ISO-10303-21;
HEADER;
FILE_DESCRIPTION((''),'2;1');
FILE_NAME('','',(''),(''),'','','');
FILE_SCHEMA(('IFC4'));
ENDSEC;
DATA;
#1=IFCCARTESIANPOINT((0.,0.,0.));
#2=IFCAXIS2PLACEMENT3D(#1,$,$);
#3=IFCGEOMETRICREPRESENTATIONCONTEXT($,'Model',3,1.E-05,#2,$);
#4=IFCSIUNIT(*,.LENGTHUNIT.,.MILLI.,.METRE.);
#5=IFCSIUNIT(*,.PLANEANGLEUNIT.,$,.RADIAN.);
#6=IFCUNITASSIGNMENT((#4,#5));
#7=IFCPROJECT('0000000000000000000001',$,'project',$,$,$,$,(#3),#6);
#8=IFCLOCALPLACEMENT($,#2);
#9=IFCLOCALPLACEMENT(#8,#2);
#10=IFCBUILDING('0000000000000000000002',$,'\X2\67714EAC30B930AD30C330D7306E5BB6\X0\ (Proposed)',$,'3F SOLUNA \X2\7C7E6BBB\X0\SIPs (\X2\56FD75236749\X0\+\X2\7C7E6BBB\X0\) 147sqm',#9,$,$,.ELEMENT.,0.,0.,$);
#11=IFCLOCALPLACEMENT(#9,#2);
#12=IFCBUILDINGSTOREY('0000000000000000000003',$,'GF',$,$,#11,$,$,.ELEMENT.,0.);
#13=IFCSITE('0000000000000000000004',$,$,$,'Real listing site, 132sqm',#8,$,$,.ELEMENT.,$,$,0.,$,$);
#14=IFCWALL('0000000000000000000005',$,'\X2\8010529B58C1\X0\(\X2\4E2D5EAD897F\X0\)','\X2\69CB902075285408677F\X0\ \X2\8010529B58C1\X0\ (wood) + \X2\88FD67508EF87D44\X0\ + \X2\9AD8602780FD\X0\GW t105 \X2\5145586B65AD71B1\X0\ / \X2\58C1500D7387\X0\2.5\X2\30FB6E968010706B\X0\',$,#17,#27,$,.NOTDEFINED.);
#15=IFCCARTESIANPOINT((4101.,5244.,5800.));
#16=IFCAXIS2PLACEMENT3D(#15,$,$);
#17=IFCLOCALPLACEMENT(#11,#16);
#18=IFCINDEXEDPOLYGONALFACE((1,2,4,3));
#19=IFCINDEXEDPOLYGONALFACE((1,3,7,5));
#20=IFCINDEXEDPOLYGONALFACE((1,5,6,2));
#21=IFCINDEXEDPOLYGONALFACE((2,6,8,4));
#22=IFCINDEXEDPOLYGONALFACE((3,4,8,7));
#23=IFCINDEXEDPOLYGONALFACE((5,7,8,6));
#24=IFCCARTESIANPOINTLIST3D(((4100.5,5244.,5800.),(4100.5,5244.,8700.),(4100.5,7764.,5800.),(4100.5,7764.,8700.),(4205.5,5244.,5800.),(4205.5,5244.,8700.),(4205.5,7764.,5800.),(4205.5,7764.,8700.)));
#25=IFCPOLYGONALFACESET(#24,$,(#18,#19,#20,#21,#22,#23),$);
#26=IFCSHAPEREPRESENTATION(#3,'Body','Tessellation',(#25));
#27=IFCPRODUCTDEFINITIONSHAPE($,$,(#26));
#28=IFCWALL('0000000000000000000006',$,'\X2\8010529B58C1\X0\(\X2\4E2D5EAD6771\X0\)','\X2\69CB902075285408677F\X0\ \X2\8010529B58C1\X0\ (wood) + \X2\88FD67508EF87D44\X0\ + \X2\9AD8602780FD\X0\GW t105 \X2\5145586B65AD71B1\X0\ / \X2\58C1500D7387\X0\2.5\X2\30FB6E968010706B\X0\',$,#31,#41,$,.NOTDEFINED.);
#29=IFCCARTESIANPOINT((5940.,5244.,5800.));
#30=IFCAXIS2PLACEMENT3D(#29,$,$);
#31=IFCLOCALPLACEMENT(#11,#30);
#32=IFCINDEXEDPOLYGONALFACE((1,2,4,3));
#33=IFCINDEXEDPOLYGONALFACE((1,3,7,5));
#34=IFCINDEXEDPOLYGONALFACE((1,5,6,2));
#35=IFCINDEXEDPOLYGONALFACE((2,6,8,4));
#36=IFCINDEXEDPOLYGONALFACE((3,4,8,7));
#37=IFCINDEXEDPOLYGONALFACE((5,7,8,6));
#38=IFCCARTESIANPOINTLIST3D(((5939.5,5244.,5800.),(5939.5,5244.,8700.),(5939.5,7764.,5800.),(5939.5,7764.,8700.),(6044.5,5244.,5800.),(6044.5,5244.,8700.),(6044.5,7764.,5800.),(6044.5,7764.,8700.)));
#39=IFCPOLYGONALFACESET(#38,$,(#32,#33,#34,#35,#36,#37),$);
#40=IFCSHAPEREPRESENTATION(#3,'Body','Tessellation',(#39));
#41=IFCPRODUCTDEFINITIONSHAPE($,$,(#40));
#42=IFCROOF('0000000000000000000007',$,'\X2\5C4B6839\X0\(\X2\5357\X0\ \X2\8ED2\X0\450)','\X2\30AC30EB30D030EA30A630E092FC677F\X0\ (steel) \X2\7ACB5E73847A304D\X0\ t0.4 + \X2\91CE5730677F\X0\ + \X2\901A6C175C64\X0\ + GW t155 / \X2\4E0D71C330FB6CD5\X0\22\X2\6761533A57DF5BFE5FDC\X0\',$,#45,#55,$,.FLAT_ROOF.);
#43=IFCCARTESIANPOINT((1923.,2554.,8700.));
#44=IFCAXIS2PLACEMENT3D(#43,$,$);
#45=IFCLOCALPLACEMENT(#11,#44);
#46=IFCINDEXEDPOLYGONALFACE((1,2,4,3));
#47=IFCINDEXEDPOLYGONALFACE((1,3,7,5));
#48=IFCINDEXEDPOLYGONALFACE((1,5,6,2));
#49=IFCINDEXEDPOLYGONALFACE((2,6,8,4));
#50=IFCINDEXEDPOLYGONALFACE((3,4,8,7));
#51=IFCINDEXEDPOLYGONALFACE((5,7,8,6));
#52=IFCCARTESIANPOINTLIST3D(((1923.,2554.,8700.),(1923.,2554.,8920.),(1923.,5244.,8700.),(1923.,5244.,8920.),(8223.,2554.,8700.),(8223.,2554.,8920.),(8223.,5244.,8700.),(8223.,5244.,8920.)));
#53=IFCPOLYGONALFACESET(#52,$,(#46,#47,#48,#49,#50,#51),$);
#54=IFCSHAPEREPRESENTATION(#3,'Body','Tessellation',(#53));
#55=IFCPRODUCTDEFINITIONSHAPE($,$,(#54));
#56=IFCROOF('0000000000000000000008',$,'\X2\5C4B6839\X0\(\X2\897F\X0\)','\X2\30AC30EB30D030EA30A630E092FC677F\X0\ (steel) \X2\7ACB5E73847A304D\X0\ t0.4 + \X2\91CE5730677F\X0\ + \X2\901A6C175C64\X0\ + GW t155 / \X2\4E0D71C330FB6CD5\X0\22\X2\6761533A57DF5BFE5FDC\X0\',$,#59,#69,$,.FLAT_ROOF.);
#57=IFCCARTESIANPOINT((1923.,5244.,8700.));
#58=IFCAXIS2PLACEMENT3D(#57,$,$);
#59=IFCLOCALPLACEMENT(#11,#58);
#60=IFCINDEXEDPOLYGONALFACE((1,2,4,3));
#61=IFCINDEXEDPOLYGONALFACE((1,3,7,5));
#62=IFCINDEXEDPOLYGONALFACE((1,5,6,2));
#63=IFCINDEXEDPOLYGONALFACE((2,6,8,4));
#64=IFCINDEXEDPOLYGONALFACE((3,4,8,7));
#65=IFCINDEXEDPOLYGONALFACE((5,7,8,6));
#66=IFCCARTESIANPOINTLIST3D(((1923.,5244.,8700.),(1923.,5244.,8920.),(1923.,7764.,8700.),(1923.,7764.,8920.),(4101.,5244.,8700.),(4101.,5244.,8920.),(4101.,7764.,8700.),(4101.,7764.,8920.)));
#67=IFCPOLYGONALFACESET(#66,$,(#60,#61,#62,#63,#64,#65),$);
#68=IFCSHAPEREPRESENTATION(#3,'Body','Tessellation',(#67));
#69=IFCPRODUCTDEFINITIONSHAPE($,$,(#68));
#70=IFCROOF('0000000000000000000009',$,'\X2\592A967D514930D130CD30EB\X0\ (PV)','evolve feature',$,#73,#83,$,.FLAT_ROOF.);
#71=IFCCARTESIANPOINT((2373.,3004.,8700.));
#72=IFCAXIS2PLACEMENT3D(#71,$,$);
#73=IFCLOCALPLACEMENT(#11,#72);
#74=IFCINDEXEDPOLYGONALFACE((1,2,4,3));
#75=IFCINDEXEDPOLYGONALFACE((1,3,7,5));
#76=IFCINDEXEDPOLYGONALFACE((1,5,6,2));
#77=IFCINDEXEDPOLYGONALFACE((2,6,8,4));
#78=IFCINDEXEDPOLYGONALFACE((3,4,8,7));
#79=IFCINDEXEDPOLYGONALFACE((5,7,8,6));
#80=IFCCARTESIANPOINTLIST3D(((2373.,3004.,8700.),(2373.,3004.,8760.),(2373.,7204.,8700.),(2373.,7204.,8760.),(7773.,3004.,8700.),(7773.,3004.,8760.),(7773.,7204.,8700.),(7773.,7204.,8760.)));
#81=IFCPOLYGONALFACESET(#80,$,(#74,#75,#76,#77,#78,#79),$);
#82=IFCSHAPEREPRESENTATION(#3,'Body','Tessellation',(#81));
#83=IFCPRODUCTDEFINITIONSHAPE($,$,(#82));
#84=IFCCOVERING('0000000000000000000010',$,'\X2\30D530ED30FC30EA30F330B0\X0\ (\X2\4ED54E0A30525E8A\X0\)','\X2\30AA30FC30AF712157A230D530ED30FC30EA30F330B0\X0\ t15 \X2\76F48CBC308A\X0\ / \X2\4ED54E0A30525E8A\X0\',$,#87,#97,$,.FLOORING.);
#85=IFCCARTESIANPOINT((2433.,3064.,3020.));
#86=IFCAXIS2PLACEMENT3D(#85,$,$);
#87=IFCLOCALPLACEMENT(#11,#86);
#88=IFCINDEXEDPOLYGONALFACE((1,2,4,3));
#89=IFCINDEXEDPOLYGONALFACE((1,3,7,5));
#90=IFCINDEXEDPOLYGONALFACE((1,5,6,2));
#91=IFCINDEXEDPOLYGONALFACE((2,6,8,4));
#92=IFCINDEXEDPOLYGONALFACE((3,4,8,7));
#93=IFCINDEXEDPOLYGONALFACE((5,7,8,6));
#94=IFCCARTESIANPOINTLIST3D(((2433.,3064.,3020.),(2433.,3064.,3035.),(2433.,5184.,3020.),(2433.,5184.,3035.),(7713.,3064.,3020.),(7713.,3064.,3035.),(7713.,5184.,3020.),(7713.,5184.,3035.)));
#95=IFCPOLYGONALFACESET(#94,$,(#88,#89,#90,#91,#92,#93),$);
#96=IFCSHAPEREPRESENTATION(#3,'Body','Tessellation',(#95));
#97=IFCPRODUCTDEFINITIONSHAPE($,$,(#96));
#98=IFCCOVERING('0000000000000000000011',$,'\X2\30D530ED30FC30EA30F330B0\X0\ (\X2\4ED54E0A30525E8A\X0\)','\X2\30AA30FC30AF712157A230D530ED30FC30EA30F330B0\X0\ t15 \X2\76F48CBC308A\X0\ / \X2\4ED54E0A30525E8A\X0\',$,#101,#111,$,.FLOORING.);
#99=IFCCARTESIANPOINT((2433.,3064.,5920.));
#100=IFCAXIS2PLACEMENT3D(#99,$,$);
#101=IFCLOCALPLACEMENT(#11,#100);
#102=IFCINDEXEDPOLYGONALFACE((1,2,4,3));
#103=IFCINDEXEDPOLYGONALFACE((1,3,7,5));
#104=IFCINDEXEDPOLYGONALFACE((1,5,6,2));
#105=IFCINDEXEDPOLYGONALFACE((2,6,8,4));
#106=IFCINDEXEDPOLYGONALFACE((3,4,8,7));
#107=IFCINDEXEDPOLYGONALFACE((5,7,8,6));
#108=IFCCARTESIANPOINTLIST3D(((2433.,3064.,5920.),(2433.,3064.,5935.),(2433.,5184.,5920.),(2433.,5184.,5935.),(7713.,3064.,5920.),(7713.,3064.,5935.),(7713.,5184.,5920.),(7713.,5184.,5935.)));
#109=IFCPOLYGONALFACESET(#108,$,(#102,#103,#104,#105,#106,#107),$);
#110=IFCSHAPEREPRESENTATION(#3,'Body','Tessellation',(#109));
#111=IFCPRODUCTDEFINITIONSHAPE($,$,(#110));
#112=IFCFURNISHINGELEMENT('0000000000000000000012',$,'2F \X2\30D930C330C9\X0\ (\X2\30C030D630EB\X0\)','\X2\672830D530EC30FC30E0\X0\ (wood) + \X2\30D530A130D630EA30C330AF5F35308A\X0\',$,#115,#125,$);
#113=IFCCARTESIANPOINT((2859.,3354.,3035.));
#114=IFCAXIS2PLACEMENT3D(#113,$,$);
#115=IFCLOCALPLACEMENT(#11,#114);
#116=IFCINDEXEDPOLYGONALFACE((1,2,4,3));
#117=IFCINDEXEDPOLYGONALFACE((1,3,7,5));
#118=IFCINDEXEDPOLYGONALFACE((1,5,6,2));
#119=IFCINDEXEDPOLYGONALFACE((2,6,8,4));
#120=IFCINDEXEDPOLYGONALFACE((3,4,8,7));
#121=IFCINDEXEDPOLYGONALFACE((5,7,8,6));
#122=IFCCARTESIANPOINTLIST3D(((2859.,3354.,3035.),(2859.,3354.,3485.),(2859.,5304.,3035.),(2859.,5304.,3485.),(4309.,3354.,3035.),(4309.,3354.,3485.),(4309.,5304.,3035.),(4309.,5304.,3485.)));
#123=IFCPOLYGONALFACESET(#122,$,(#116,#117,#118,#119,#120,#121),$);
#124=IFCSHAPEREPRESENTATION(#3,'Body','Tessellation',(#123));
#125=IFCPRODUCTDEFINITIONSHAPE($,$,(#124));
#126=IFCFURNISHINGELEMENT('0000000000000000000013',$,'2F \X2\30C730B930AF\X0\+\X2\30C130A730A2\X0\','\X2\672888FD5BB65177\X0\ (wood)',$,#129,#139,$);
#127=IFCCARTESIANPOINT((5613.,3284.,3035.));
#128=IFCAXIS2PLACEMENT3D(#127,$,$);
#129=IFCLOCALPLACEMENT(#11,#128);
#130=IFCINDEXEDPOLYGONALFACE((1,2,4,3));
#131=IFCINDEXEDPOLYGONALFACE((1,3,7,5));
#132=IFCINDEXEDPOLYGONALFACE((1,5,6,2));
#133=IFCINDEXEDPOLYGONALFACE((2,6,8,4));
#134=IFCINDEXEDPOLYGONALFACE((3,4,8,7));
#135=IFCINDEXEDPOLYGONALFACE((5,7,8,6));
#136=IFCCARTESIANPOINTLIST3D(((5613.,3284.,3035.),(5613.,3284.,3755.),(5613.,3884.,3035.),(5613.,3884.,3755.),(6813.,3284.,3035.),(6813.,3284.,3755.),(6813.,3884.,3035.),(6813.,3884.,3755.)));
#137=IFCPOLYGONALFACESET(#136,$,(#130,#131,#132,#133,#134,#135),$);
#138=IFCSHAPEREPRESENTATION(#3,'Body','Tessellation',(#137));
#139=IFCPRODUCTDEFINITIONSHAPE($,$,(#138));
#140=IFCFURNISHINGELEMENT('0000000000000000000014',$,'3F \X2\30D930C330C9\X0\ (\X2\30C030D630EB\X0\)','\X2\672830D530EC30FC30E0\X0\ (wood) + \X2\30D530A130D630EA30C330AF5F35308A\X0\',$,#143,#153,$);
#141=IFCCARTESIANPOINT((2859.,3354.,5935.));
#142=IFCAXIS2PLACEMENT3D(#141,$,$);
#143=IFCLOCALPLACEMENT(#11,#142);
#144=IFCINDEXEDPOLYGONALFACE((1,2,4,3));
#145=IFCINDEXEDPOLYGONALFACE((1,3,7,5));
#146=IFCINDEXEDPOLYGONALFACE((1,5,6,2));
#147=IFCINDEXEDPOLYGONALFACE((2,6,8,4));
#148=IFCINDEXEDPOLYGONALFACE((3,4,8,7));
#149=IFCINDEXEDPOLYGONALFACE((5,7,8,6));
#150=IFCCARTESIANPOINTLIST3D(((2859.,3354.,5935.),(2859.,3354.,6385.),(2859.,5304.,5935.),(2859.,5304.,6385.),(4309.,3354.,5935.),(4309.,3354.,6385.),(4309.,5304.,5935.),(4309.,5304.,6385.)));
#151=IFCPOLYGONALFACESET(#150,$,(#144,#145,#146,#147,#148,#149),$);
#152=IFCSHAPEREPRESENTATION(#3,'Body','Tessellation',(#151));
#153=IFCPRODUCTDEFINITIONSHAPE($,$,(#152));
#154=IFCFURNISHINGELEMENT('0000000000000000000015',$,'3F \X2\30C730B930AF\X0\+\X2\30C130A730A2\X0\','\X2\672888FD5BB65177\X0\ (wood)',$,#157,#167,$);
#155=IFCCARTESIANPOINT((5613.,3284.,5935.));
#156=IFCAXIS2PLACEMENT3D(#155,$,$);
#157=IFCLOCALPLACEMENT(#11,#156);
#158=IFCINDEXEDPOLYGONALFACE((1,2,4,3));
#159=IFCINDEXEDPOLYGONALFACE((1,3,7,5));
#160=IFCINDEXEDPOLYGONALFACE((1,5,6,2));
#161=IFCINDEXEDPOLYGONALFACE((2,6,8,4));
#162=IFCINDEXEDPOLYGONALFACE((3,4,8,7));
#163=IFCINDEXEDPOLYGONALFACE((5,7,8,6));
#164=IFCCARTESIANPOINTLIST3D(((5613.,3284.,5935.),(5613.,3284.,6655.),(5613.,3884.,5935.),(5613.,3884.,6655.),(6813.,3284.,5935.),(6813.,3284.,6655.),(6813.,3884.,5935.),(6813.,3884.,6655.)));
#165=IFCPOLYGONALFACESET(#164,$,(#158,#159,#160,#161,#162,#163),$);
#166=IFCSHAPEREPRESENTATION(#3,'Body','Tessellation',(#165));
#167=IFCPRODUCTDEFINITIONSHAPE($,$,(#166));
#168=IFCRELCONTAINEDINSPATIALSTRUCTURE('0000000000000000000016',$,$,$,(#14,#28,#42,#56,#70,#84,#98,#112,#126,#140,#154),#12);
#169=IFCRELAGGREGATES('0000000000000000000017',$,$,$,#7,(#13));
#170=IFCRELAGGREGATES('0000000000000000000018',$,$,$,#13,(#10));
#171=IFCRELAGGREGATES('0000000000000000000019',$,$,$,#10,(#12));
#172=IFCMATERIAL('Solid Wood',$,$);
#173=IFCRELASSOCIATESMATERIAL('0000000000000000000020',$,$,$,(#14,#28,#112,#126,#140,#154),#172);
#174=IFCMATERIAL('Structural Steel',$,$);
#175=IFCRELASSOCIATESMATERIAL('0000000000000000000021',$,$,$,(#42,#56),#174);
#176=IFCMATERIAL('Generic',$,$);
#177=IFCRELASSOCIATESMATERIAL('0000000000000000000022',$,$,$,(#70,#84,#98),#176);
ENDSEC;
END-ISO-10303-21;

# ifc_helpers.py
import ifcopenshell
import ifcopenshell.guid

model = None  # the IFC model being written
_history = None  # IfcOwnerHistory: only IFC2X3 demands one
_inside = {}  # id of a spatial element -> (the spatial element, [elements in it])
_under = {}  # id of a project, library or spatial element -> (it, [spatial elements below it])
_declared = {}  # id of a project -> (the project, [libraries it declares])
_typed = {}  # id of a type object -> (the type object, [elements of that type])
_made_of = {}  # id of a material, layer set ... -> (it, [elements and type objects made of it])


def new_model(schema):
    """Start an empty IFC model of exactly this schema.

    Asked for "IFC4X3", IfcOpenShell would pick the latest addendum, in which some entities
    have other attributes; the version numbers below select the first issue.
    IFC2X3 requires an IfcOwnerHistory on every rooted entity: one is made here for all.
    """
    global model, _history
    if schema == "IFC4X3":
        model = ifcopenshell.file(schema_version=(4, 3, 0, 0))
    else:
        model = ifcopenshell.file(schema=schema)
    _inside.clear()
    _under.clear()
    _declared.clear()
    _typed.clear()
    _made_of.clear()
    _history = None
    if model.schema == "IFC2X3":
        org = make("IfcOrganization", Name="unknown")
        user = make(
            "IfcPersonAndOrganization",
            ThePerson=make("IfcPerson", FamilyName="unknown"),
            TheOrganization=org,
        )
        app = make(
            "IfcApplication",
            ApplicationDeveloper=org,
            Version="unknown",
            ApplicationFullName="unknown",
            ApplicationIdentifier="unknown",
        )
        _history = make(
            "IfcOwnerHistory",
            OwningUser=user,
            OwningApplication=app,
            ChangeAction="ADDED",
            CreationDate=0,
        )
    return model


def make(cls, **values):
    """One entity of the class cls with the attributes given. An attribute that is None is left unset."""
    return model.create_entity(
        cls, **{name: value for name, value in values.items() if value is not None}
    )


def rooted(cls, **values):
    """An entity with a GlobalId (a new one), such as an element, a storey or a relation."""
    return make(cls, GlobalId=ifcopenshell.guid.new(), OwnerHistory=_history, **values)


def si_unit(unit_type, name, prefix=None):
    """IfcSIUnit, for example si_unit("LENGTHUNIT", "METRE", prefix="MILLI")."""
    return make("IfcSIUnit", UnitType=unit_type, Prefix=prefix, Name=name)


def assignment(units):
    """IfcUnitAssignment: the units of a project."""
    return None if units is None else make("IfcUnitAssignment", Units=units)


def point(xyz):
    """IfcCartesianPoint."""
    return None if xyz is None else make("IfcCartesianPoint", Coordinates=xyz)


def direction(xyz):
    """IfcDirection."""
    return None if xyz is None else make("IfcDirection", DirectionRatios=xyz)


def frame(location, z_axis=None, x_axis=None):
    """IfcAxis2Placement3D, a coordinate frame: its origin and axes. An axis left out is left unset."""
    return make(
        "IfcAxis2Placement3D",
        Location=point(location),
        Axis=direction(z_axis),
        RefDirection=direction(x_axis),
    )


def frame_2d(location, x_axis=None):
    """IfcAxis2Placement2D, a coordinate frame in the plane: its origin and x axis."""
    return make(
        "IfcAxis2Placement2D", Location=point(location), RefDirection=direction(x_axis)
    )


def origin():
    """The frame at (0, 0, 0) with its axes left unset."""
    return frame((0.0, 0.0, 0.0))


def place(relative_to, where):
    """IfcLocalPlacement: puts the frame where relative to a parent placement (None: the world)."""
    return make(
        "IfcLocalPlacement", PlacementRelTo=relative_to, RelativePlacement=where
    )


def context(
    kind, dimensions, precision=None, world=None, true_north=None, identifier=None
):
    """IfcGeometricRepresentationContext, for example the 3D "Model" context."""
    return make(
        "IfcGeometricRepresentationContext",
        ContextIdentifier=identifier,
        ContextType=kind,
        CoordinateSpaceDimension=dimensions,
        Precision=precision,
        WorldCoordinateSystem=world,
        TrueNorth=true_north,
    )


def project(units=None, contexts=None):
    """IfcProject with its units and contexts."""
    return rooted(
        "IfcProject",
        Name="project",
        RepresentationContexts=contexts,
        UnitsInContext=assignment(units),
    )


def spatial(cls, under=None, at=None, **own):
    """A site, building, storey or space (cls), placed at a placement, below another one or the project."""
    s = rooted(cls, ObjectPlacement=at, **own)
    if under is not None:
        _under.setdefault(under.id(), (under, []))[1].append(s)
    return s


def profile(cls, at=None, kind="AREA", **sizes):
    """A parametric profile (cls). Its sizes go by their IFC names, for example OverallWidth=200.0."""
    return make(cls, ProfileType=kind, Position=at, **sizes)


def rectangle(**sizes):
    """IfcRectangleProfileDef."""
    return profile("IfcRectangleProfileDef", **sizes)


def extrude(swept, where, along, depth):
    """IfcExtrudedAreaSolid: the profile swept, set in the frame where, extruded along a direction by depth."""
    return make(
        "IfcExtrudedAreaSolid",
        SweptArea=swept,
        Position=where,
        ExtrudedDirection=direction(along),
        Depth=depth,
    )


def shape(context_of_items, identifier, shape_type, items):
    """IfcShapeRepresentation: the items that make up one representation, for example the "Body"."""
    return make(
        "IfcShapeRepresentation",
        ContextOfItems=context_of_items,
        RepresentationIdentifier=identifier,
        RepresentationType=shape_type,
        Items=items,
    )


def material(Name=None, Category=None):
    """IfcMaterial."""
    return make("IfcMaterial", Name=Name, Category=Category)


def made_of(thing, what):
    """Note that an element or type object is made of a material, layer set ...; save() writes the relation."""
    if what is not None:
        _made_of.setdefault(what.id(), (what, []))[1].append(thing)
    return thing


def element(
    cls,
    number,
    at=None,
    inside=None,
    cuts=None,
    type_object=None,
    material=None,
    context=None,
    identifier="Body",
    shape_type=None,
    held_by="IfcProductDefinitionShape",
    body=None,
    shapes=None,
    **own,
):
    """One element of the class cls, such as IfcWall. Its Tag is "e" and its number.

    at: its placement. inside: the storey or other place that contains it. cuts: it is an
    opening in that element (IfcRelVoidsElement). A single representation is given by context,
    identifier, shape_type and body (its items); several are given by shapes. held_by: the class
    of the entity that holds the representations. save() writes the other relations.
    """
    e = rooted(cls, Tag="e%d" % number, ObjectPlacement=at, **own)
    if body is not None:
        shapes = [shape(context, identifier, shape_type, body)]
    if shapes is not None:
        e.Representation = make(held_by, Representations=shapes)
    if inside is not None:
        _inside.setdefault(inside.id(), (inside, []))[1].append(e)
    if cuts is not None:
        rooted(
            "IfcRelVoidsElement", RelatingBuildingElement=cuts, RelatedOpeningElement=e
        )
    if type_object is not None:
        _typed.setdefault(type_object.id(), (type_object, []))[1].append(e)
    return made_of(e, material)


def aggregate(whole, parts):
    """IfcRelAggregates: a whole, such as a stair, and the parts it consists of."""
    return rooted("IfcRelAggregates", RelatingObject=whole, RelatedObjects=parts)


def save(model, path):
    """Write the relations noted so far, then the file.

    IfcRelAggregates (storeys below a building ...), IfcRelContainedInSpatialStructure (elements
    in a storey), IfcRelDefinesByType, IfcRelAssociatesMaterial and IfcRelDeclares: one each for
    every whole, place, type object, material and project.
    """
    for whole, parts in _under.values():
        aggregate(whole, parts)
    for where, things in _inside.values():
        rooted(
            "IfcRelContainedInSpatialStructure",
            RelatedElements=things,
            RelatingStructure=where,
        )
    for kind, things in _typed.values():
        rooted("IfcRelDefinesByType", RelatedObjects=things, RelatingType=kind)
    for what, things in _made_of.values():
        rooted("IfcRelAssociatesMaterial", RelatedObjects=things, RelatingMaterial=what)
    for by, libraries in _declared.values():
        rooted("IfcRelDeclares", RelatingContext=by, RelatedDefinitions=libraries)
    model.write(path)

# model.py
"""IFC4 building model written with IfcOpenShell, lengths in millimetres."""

from ifc_helpers import new_model, si_unit, frame, frame_2d, origin, place, context, project, spatial, rectangle, extrude, material, element, save


model = new_model("IFC4")

# Units and contexts
model_context = context("Model", 3, precision=1e-05, world=origin())
ifc_project = project(units=[si_unit("LENGTHUNIT", "METRE", prefix="MILLI"), si_unit("PLANEANGLEUNIT", "RADIAN")], contexts=[model_context])

# Site, building, storey
site_placement = place(None, origin())
site = spatial("IfcSite", under=ifc_project, at=site_placement, ObjectType="Real listing site, 132sqm", CompositionType="ELEMENT", RefElevation=0.0)
building_placement = place(site_placement, origin())
building = spatial("IfcBuilding", under=site, at=building_placement, Name="東京スキップの家 (Proposed)", ObjectType="3F SOLUNA 籾殻SIPs (国産杉+籾殻) 147sqm", CompositionType="ELEMENT", ElevationOfRefHeight=0.0, ElevationOfTerrain=0.0)
storey_placement = place(building_placement, origin())
storey = spatial("IfcBuildingStorey", under=building, at=storey_placement, Name="GF", CompositionType="ELEMENT", Elevation=0.0)

# Shared definitions
ifc_material_1 = material(Name="Solid Wood")

# Walls
wall_1_placement = place(storey_placement, frame((4101.0, 5244.0, 5800.0)))
element("IfcWall", 1, at=wall_1_placement, inside=storey, material=ifc_material_1, Name="耐力壁(中庭西)", Description="構造用合板 耐力壁 (wood) + 製材軸組 + 高性能GW t105 充填断熱 / 壁倍率2.5・準耐火", PredefinedType="NOTDEFINED", context=model_context, shape_type="SweptSolid", body=[
    extrude(rectangle(XDim=105.0, YDim=2520.0, at=frame_2d((52.0, 1260.0))), frame((4101.0, 5244.0, 5800.0)), (0.0, 0.0, 1.0), 2900.0),
])
wall_2_placement = place(storey_placement, frame((5940.0, 5244.0, 5800.0)))
element("IfcWall", 2, at=wall_2_placement, inside=storey, material=ifc_material_1, Name="耐力壁(中庭東)", Description="構造用合板 耐力壁 (wood) + 製材軸組 + 高性能GW t105 充填断熱 / 壁倍率2.5・準耐火", PredefinedType="NOTDEFINED", context=model_context, shape_type="SweptSolid", body=[
    extrude(rectangle(XDim=105.0, YDim=2520.0, at=frame_2d((52.0, 1260.0))), frame((5940.0, 5244.0, 5800.0)), (0.0, 0.0, 1.0), 2900.0),
])

# Roofs
ifc_material_2 = material(Name="Structural Steel")
roof_1_placement = place(storey_placement, frame((1923.0, 2554.0, 8700.0)))
element("IfcRoof", 3, at=roof_1_placement, inside=storey, material=ifc_material_2, Name="屋根(南 軒450)", Description="ガルバリウム鋼板 (steel) 立平葺き t0.4 + 野地板 + 通気層 + GW t155 / 不燃・法22条区域対応", PredefinedType="FLAT_ROOF", context=model_context, shape_type="SweptSolid", body=[
    extrude(rectangle(XDim=6300.0, YDim=2690.0, at=frame_2d((3150.0, 1345.0))), frame((1923.0, 2554.0, 8700.0)), (0.0, 0.0, 1.0), 220.0),
])
roof_2_placement = place(storey_placement, frame((1923.0, 5244.0, 8700.0)))
element("IfcRoof", 4, at=roof_2_placement, inside=storey, material=ifc_material_2, Name="屋根(西)", Description="ガルバリウム鋼板 (steel) 立平葺き t0.4 + 野地板 + 通気層 + GW t155 / 不燃・法22条区域対応", PredefinedType="FLAT_ROOF", context=model_context, shape_type="SweptSolid", body=[
    extrude(rectangle(XDim=2178.0, YDim=2520.0, at=frame_2d((1089.0, 1260.0))), frame((1923.0, 5244.0, 8700.0)), (0.0, 0.0, 1.0), 220.0),
])
ifc_material_3 = material(Name="Generic")
roof_3_placement = place(storey_placement, frame((2373.0, 3004.0, 8700.0)))
element("IfcRoof", 5, at=roof_3_placement, inside=storey, material=ifc_material_3, Name="太陽光パネル (PV)", Description="evolve feature", PredefinedType="FLAT_ROOF", context=model_context, shape_type="SweptSolid", body=[
    extrude(rectangle(XDim=5400.0, YDim=4200.0, at=frame_2d((2700.0, 2100.0))), frame((2373.0, 3004.0, 8700.0)), (0.0, 0.0, 1.0), 60.0),
])

# Coverings
covering_1_placement = place(storey_placement, frame((2433.0, 3064.0, 3020.0)))
element("IfcCovering", 6, at=covering_1_placement, inside=storey, material=ifc_material_3, Name="フローリング (仕上げ床)", Description="オーク無垢フローリング t15 直貼り / 仕上げ床", PredefinedType="FLOORING", context=model_context, shape_type="SweptSolid", body=[
    extrude(rectangle(XDim=5280.0, YDim=2120.0, at=frame_2d((2640.0, 1060.0))), frame((2433.0, 3064.0, 3020.0)), (0.0, 0.0, 1.0), 15.0),
])
covering_2_placement = place(storey_placement, frame((2433.0, 3064.0, 5920.0)))
element("IfcCovering", 7, at=covering_2_placement, inside=storey, material=ifc_material_3, Name="フローリング (仕上げ床)", Description="オーク無垢フローリング t15 直貼り / 仕上げ床", PredefinedType="FLOORING", context=model_context, shape_type="SweptSolid", body=[
    extrude(rectangle(XDim=5280.0, YDim=2120.0, at=frame_2d((2640.0, 1060.0))), frame((2433.0, 3064.0, 5920.0)), (0.0, 0.0, 1.0), 15.0),
])

# Furnishing elements
furnishing_1_placement = place(storey_placement, frame((2859.0, 3354.0, 3035.0)))
element("IfcFurnishingElement", 8, at=furnishing_1_placement, inside=storey, material=ifc_material_1, Name="2F ベッド (ダブル)", Description="木フレーム (wood) + ファブリック張り", context=model_context, shape_type="SweptSolid", body=[
    extrude(rectangle(XDim=1450.0, YDim=1950.0, at=frame_2d((725.0, 975.0))), frame((2859.0, 3354.0, 3035.0)), (0.0, 0.0, 1.0), 450.0),
])
furnishing_2_placement = place(storey_placement, frame((5613.0, 3284.0, 3035.0)))
element("IfcFurnishingElement", 9, at=furnishing_2_placement, inside=storey, material=ifc_material_1, Name="2F デスク+チェア", Description="木製家具 (wood)", context=model_context, shape_type="SweptSolid", body=[
    extrude(rectangle(XDim=1200.0, YDim=600.0, at=frame_2d((600.0, 300.0))), frame((5613.0, 3284.0, 3035.0)), (0.0, 0.0, 1.0), 720.0),
])
furnishing_3_placement = place(storey_placement, frame((2859.0, 3354.0, 5935.0)))
element("IfcFurnishingElement", 10, at=furnishing_3_placement, inside=storey, material=ifc_material_1, Name="3F ベッド (ダブル)", Description="木フレーム (wood) + ファブリック張り", context=model_context, shape_type="SweptSolid", body=[
    extrude(rectangle(XDim=1450.0, YDim=1950.0, at=frame_2d((725.0, 975.0))), frame((2859.0, 3354.0, 5935.0)), (0.0, 0.0, 1.0), 450.0),
])
furnishing_4_placement = place(storey_placement, frame((5613.0, 3284.0, 5935.0)))
element("IfcFurnishingElement", 11, at=furnishing_4_placement, inside=storey, material=ifc_material_1, Name="3F デスク+チェア", Description="木製家具 (wood)", context=model_context, shape_type="SweptSolid", body=[
    extrude(rectangle(XDim=1200.0, YDim=600.0, at=frame_2d((600.0, 300.0))), frame((5613.0, 3284.0, 5935.0)), (0.0, 0.0, 1.0), 720.0),
])

save(model, "model.ifc")
